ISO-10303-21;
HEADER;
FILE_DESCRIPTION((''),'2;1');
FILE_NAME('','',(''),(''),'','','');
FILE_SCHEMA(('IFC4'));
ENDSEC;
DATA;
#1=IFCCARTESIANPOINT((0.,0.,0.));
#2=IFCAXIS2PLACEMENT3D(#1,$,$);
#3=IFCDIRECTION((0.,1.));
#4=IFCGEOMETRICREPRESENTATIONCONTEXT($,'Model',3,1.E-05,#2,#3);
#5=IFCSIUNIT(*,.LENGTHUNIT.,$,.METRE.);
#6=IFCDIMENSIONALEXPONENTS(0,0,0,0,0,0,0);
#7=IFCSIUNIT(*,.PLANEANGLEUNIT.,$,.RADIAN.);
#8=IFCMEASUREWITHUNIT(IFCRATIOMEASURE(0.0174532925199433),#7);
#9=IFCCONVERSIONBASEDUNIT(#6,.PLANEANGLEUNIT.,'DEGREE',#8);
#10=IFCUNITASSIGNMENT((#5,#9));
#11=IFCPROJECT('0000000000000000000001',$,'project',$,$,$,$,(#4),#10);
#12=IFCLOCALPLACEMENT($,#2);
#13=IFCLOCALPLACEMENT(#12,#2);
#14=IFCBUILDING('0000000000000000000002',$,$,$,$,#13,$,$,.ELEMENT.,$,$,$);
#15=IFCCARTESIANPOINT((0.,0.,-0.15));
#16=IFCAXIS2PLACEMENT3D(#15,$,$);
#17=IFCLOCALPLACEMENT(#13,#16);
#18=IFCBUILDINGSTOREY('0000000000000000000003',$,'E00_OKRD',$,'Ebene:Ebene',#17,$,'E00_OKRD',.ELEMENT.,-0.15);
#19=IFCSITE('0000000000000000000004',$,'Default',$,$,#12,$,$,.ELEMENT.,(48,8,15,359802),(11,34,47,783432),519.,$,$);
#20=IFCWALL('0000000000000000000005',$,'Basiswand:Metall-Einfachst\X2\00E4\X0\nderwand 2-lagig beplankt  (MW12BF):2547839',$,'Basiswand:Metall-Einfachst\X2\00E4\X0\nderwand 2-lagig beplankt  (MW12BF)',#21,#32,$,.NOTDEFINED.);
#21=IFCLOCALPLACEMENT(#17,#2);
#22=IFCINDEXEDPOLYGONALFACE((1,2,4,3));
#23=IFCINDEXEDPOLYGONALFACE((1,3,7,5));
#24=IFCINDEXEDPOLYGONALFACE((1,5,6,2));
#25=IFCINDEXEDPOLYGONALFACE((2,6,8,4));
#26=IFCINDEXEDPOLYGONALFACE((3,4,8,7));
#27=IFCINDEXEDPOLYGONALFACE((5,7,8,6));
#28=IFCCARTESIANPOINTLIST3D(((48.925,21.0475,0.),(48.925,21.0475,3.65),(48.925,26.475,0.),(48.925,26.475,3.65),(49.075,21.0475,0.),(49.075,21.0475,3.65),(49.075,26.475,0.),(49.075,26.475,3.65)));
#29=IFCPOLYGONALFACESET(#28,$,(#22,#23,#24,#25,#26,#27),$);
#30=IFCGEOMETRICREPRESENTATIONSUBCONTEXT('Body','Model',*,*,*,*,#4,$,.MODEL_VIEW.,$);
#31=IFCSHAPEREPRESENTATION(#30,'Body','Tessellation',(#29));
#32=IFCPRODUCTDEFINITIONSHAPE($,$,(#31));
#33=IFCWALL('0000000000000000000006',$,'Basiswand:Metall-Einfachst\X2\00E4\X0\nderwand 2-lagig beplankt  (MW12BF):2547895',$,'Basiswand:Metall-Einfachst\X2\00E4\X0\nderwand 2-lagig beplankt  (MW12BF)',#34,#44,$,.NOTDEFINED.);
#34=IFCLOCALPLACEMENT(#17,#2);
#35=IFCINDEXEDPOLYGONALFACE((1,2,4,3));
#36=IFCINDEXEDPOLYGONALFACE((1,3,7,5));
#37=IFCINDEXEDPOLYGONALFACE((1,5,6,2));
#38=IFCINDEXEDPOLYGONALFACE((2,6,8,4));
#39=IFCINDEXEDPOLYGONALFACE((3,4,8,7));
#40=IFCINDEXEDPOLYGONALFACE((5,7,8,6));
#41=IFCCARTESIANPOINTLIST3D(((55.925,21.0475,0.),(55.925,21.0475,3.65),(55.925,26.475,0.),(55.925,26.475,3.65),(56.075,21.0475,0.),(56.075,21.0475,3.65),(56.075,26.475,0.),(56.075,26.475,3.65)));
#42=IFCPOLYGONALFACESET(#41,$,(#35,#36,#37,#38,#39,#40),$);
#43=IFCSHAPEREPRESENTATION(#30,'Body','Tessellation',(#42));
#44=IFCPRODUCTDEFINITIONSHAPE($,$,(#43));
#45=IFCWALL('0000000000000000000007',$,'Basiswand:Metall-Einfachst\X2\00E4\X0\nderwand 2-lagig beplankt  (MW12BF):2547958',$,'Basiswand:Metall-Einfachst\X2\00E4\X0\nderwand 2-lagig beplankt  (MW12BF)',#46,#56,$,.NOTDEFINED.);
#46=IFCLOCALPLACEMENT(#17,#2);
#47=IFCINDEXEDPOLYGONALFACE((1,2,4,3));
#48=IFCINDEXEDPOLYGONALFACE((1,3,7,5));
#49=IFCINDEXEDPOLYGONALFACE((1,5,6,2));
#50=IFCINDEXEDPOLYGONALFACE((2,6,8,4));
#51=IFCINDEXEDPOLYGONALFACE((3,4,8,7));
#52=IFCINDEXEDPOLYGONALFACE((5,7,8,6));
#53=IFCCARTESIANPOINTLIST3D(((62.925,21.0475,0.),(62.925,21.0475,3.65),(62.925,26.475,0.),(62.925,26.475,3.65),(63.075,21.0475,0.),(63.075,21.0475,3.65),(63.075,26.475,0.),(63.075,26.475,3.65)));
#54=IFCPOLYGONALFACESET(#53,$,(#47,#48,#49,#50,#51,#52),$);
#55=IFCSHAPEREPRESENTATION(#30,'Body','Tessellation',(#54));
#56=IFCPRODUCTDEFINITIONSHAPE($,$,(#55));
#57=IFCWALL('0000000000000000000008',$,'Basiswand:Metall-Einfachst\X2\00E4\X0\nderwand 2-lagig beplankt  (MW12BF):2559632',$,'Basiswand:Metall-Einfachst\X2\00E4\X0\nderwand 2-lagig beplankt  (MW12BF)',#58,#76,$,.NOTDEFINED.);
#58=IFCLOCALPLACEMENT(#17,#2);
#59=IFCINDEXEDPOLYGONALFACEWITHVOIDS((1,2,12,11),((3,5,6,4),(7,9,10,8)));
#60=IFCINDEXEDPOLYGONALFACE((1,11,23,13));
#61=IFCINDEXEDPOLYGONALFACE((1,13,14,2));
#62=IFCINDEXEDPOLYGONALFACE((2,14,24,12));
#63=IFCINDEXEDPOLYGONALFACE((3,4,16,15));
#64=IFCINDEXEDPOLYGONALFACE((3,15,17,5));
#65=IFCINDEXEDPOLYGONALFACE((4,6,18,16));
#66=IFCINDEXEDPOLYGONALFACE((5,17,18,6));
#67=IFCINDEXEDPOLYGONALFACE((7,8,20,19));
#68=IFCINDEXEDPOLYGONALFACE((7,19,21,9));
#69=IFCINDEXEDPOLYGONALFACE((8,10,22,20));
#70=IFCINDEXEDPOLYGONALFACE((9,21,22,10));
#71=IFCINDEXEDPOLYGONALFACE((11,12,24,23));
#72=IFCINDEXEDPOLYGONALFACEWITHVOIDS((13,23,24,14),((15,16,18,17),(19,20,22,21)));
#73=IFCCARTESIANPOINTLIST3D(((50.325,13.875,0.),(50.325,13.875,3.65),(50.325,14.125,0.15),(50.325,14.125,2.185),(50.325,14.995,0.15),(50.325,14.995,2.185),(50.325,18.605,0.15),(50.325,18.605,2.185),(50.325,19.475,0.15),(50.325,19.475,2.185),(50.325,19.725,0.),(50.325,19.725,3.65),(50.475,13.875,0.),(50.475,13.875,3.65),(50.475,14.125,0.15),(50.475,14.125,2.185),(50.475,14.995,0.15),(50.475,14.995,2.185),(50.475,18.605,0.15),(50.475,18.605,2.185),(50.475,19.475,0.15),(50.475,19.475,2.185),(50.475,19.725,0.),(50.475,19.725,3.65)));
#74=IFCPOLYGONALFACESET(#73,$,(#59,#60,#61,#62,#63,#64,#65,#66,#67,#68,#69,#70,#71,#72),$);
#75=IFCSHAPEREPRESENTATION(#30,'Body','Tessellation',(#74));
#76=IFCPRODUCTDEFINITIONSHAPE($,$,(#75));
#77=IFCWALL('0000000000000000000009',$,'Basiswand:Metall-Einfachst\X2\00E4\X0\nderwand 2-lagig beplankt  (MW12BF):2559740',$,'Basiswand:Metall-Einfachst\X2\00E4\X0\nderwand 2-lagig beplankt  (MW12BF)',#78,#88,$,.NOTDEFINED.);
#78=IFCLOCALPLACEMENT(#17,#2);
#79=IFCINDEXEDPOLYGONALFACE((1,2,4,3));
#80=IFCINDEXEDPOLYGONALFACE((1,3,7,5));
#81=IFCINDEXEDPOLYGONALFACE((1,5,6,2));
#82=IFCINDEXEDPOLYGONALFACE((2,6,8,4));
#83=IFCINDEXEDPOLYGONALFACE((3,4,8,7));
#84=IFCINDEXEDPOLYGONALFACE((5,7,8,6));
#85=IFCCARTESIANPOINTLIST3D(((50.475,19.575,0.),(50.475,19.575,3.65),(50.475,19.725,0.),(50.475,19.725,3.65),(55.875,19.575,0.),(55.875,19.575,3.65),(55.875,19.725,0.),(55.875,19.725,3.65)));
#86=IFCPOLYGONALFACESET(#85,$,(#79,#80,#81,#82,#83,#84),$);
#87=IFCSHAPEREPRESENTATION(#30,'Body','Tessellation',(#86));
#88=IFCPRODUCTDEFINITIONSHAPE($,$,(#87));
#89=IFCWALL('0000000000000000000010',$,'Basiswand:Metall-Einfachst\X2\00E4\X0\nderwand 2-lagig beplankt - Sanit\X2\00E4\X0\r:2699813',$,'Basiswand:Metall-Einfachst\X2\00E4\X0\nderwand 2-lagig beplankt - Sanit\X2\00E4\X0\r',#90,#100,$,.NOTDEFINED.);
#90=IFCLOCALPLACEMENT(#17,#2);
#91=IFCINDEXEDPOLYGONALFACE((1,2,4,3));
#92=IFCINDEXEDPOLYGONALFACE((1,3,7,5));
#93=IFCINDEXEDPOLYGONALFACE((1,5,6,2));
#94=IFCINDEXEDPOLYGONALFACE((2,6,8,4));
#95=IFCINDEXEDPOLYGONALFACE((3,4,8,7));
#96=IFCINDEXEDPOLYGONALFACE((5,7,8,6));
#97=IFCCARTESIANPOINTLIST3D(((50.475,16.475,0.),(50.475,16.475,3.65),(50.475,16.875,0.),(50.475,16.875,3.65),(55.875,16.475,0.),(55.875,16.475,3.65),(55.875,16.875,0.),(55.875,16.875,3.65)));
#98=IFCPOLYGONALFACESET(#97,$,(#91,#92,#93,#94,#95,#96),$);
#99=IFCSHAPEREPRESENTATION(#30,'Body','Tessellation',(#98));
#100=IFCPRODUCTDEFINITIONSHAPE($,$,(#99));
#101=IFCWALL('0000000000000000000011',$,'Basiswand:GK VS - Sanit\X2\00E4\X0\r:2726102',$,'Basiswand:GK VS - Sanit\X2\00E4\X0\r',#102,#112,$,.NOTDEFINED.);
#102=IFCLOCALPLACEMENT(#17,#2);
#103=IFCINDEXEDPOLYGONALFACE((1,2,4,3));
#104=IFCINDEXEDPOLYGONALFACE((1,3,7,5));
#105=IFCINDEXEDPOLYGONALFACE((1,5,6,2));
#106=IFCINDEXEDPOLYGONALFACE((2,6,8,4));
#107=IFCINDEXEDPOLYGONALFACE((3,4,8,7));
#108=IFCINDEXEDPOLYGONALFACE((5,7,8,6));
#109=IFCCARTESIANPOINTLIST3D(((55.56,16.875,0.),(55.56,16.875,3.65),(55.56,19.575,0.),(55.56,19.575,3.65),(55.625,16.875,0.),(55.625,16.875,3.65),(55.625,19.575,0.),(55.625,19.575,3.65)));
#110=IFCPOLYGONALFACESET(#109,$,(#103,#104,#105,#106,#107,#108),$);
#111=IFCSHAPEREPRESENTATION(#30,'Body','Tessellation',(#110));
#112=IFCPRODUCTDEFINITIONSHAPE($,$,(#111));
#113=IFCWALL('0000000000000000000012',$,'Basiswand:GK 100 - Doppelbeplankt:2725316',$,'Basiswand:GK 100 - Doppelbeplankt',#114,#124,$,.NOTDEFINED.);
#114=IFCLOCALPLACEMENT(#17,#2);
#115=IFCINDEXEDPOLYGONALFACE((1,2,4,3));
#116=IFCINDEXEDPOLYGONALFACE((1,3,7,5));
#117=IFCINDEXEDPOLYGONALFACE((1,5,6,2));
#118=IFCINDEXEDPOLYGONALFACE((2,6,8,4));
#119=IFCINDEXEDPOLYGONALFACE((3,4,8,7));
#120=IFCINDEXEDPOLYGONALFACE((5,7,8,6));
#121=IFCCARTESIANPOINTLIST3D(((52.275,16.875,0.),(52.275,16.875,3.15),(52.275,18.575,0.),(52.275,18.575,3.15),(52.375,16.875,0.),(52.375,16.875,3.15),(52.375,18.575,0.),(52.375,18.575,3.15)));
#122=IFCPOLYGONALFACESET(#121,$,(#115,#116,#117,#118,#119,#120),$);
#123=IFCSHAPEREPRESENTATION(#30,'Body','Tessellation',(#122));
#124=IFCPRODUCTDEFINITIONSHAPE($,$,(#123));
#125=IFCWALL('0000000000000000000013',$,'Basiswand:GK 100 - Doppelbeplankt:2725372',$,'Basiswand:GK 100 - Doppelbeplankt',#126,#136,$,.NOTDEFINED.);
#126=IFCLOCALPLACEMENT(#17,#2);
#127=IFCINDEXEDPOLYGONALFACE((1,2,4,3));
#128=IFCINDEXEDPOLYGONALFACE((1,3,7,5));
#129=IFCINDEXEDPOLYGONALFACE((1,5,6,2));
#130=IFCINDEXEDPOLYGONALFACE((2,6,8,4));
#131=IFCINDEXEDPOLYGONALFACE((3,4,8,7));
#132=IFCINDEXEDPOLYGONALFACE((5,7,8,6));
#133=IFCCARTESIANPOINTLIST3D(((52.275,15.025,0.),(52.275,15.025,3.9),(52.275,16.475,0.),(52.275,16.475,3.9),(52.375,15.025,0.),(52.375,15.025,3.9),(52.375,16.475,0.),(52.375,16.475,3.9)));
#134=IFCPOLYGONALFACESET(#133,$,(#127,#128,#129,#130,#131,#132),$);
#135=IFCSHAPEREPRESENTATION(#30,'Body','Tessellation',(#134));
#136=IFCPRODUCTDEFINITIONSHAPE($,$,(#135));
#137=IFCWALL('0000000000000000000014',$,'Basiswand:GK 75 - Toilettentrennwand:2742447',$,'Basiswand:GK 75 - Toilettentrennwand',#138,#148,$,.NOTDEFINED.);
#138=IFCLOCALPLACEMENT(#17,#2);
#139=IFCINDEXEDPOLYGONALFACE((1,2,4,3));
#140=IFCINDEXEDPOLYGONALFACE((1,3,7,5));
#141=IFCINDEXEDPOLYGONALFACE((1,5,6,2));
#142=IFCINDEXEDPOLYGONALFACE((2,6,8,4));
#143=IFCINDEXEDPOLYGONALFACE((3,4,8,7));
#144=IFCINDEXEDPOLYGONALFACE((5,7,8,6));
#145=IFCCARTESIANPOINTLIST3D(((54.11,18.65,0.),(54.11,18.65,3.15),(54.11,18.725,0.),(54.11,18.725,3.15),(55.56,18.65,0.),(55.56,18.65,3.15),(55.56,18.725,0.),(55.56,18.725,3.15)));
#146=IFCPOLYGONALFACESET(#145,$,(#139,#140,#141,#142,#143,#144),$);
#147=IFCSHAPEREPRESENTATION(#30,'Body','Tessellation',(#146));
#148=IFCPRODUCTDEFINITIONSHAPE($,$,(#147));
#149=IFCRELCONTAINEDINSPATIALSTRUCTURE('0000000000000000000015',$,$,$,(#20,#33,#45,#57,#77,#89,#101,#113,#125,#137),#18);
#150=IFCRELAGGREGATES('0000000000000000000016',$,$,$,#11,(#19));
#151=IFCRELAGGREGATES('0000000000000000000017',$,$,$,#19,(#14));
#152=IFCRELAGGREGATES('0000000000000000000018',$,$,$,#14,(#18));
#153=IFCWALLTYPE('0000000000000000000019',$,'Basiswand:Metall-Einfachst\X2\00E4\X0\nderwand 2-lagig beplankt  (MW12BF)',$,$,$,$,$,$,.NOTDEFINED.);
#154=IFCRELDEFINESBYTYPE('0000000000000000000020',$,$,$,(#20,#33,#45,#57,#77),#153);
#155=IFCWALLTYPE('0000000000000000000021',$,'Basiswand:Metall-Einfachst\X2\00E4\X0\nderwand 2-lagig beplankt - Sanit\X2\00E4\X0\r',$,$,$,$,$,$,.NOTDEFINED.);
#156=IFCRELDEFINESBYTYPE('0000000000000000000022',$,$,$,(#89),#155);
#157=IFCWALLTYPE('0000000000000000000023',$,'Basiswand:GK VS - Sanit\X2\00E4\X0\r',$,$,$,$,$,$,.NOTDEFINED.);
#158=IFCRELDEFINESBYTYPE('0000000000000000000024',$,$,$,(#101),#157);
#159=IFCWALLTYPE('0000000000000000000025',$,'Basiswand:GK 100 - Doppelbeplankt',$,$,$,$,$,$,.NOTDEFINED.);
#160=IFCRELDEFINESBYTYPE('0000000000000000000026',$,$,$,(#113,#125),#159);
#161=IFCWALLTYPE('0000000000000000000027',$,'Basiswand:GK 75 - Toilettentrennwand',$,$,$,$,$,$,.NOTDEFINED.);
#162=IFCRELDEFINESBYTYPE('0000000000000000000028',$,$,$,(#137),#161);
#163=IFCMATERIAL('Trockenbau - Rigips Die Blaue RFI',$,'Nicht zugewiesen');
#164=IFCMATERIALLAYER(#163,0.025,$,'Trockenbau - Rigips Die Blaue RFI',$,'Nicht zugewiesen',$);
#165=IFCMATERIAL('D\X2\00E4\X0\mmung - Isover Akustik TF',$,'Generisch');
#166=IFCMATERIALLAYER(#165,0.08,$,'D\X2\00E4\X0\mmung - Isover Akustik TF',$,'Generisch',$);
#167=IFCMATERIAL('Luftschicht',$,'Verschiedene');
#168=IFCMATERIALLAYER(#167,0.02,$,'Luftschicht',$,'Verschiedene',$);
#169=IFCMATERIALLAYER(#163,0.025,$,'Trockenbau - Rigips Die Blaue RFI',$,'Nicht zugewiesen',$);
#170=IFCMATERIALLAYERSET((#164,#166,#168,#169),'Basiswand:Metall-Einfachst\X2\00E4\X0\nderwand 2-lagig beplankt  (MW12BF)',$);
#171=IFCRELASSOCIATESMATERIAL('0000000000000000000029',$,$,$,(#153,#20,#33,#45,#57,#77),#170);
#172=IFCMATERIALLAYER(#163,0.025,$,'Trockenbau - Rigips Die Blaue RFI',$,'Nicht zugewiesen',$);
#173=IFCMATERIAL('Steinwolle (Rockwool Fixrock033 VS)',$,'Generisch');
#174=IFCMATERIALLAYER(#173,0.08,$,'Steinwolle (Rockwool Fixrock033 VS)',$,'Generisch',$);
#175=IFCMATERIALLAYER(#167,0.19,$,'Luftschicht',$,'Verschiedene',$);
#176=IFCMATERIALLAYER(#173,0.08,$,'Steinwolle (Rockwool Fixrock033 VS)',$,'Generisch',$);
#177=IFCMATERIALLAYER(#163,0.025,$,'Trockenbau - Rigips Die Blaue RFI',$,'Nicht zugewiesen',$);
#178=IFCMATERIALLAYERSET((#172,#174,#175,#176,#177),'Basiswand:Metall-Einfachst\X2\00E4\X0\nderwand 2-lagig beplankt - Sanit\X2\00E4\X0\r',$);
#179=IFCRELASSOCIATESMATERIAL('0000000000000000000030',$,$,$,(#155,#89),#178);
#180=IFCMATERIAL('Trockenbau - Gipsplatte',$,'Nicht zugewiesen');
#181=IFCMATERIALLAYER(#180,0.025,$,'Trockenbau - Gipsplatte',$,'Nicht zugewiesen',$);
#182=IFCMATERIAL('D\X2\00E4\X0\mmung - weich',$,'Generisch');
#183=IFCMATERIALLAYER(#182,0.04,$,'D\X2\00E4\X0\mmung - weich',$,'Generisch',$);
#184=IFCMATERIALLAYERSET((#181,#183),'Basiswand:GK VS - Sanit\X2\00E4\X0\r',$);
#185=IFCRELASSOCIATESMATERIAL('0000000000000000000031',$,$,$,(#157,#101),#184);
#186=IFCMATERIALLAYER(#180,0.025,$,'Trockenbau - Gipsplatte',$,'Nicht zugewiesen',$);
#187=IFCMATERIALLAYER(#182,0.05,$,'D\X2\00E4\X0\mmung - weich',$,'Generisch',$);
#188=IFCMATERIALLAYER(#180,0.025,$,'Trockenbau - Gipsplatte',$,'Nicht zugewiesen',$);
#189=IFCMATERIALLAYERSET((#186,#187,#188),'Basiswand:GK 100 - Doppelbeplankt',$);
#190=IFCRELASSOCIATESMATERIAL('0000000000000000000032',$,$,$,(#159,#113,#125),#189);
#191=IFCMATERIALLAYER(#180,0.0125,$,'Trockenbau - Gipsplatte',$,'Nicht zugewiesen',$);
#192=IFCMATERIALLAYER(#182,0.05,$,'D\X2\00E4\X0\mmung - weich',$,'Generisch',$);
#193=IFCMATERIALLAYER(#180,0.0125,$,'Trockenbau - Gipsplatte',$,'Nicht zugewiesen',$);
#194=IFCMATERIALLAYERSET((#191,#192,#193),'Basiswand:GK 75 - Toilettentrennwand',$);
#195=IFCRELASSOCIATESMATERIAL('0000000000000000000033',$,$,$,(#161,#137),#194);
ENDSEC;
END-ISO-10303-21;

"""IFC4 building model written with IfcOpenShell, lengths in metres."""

from ifc_helpers import new_model, entity, si_unit, converted_unit, direction, frame, frame_2d, origin, place, context, subcontext, project, spatial, rectangle, extrude, material, layer, layer_set, layer_usage, type_object, element, save


model = new_model("IFC4")

# Units and contexts
model_context = context("Model", 3, precision=1e-05, world=origin(), true_north=direction((0.0, 1.0)))
body_context = subcontext(model_context, "Body", "Model", "MODEL_VIEW")
ifc_project = project(units=[si_unit("LENGTHUNIT", "METRE"), converted_unit("PLANEANGLEUNIT", "DEGREE", entity("IfcRatioMeasure", 0.0174532925199433), si_unit("PLANEANGLEUNIT", "RADIAN"), dimensions=[0, 0, 0, 0, 0, 0, 0])], contexts=[model_context])

# Site, building, storey
site_placement = place(None, frame((0.0, 0.0, 0.0)))
site = spatial("IfcSite", under=ifc_project, at=site_placement, Name="Default", CompositionType="ELEMENT", RefLatitude=(48, 8, 15, 359802), RefLongitude=(11, 34, 47, 783432), RefElevation=519.0)
building_placement = place(site_placement, origin())
building = spatial("IfcBuilding", under=site, at=building_placement, CompositionType="ELEMENT")
storey_placement = place(building_placement, frame((0.0, 0.0, -0.15)))
storey = spatial("IfcBuildingStorey", under=building, at=storey_placement, Name="E00_OKRD", ObjectType="Ebene:Ebene", LongName="E00_OKRD", CompositionType="ELEMENT", Elevation=-0.15)

# Walls
ifc_material_1 = material(Name="Trockenbau - Rigips Die Blaue RFI", Category="Nicht zugewiesen")
ifc_layer_1 = layer(ifc_material_1, 0.025, Name="Trockenbau - Rigips Die Blaue RFI", Category="Nicht zugewiesen")
ifc_material_2 = material(Name="Dämmung - Isover Akustik TF", Category="Generisch")
ifc_layer_2 = layer(ifc_material_2, 0.08, Name="Dämmung - Isover Akustik TF", Category="Generisch")
ifc_material_3 = material(Name="Luftschicht", Category="Verschiedene")
ifc_layer_3 = layer(ifc_material_3, 0.02, Name="Luftschicht", Category="Verschiedene")
ifc_layer_4 = layer(ifc_material_1, 0.025, Name="Trockenbau - Rigips Die Blaue RFI", Category="Nicht zugewiesen")
ifc_layer_set_1 = layer_set([ifc_layer_1, ifc_layer_2, ifc_layer_3, ifc_layer_4], Name="Basiswand:Metall-Einfachständerwand 2-lagig beplankt  (MW12BF)")
ifc_layer_usage_1 = layer_usage(ifc_layer_set_1, "AXIS2", "NEGATIVE", 0.075)
wall_type_1 = type_object("IfcWallType", Name="Basiswand:Metall-Einfachständerwand 2-lagig beplankt  (MW12BF)", PredefinedType="NOTDEFINED", material=ifc_layer_set_1)
wall_1_placement = place(storey_placement, frame((49.0, 26.475, 0.0), z_axis=(0.0, 0.0, 1.0), x_axis=(0.0, -1.0, 0.0)))
element("IfcWall", 1, at=wall_1_placement, inside=storey, type_object=wall_type_1, material=ifc_layer_usage_1, Name="Basiswand:Metall-Einfachständerwand 2-lagig beplankt  (MW12BF):2547839", ObjectType="Basiswand:Metall-Einfachständerwand 2-lagig beplankt  (MW12BF)", PredefinedType="NOTDEFINED", context=body_context, shape_type="SweptSolid", body=[
    extrude(rectangle(XDim=5.4275, YDim=0.15, at=frame_2d((2.7137, 0.0), x_axis=(-1.0, 0.0))), origin(), (0.0, 0.0, 1.0), 3.65),
])
ifc_layer_usage_2 = layer_usage(ifc_layer_set_1, "AXIS2", "NEGATIVE", 0.075)
wall_2_placement = place(storey_placement, frame((56.0, 26.475, 0.0), z_axis=(0.0, 0.0, 1.0), x_axis=(0.0, -1.0, 0.0)))
element("IfcWall", 2, at=wall_2_placement, inside=storey, type_object=wall_type_1, material=ifc_layer_usage_2, Name="Basiswand:Metall-Einfachständerwand 2-lagig beplankt  (MW12BF):2547895", ObjectType="Basiswand:Metall-Einfachständerwand 2-lagig beplankt  (MW12BF)", PredefinedType="NOTDEFINED", context=body_context, shape_type="SweptSolid", body=[
    extrude(rectangle(XDim=5.4275, YDim=0.15, at=frame_2d((2.7137, 0.0), x_axis=(-1.0, 0.0))), origin(), (0.0, 0.0, 1.0), 3.65),
])
ifc_layer_usage_3 = layer_usage(ifc_layer_set_1, "AXIS2", "NEGATIVE", 0.075)
wall_3_placement = place(storey_placement, frame((63.0, 26.475, 0.0), z_axis=(0.0, 0.0, 1.0), x_axis=(0.0, -1.0, 0.0)))
element("IfcWall", 3, at=wall_3_placement, inside=storey, type_object=wall_type_1, material=ifc_layer_usage_3, Name="Basiswand:Metall-Einfachständerwand 2-lagig beplankt  (MW12BF):2547958", ObjectType="Basiswand:Metall-Einfachständerwand 2-lagig beplankt  (MW12BF)", PredefinedType="NOTDEFINED", context=body_context, shape_type="SweptSolid", body=[
    extrude(rectangle(XDim=5.4275, YDim=0.15, at=frame_2d((2.7137, 0.0), x_axis=(-1.0, 0.0))), origin(), (0.0, 0.0, 1.0), 3.65),
])

# Wall, openings
ifc_layer_usage_4 = layer_usage(ifc_layer_set_1, "AXIS2", "NEGATIVE", 0.075)
wall_4_placement = place(storey_placement, frame((50.4, 19.725, 0.0), z_axis=(0.0, 0.0, 1.0), x_axis=(0.0, -1.0, 0.0)))
wall_4 = element("IfcWall", 4, at=wall_4_placement, inside=storey, type_object=wall_type_1, material=ifc_layer_usage_4, Name="Basiswand:Metall-Einfachständerwand 2-lagig beplankt  (MW12BF):2559632", ObjectType="Basiswand:Metall-Einfachständerwand 2-lagig beplankt  (MW12BF)", PredefinedType="NOTDEFINED", context=body_context, shape_type="SweptSolid", body=[
    extrude(rectangle(XDim=5.85, YDim=0.15, at=frame_2d((2.925, 0.0), x_axis=(-1.0, 0.0))), origin(), (0.0, 0.0, 1.0), 3.65),
])
opening_1_placement = place(wall_4_placement, frame((4.73, -0.075, 0.15)))
element("IfcOpeningElement", 5, at=opening_1_placement, cuts=wall_4, ObjectType="Opening", PredefinedType="OPENING", context=body_context, shape_type="SweptSolid", body=[
    extrude(rectangle(XDim=2.035, YDim=0.87, at=frame_2d((1.0175, 0.435), x_axis=(-1.0, 0.0))), frame((0.0, 0.0, 0.0), z_axis=(0.0, 1.0, 0.0), x_axis=(0.0, 0.0, 1.0)), (0.0, 0.0, 1.0), 0.15),
])
opening_2_placement = place(wall_4_placement, frame((0.25, -0.075, 0.15)))
element("IfcOpeningElement", 6, at=opening_2_placement, cuts=wall_4, ObjectType="Opening", PredefinedType="OPENING", context=body_context, shape_type="SweptSolid", body=[
    extrude(rectangle(XDim=2.035, YDim=0.87, at=frame_2d((1.0175, 0.435), x_axis=(-1.0, 0.0))), frame((0.0, 0.0, 0.0), z_axis=(0.0, 1.0, 0.0), x_axis=(0.0, 0.0, 1.0)), (0.0, 0.0, 1.0), 0.15),
])

# Walls
ifc_layer_usage_5 = layer_usage(ifc_layer_set_1, "AXIS2", "POSITIVE", -0.075)
wall_5_placement = place(storey_placement, frame((55.875, 19.65, 0.0), z_axis=(0.0, 0.0, 1.0), x_axis=(-1.0, 0.0, 0.0)))
element("IfcWall", 7, at=wall_5_placement, inside=storey, type_object=wall_type_1, material=ifc_layer_usage_5, Name="Basiswand:Metall-Einfachständerwand 2-lagig beplankt  (MW12BF):2559740", ObjectType="Basiswand:Metall-Einfachständerwand 2-lagig beplankt  (MW12BF)", PredefinedType="NOTDEFINED", context=body_context, shape_type="SweptSolid", body=[
    extrude(rectangle(XDim=5.4, YDim=0.15, at=frame_2d((2.7, 0.0), x_axis=(-1.0, 0.0))), origin(), (0.0, 0.0, 1.0), 3.65),
])
ifc_layer_5 = layer(ifc_material_1, 0.025, Name="Trockenbau - Rigips Die Blaue RFI", Category="Nicht zugewiesen")
ifc_material_4 = material(Name="Steinwolle (Rockwool Fixrock033 VS)", Category="Generisch")
ifc_layer_6 = layer(ifc_material_4, 0.08, Name="Steinwolle (Rockwool Fixrock033 VS)", Category="Generisch")
ifc_layer_7 = layer(ifc_material_3, 0.19, Name="Luftschicht", Category="Verschiedene")
ifc_layer_8 = layer(ifc_material_4, 0.08, Name="Steinwolle (Rockwool Fixrock033 VS)", Category="Generisch")
ifc_layer_9 = layer(ifc_material_1, 0.025, Name="Trockenbau - Rigips Die Blaue RFI", Category="Nicht zugewiesen")
ifc_layer_set_2 = layer_set([ifc_layer_5, ifc_layer_6, ifc_layer_7, ifc_layer_8, ifc_layer_9], Name="Basiswand:Metall-Einfachständerwand 2-lagig beplankt - Sanitär")
ifc_layer_usage_6 = layer_usage(ifc_layer_set_2, "AXIS2", "NEGATIVE", 0.2)
wall_type_2 = type_object("IfcWallType", Name="Basiswand:Metall-Einfachständerwand 2-lagig beplankt - Sanitär", PredefinedType="NOTDEFINED", material=ifc_layer_set_2)
wall_6_placement = place(storey_placement, frame((55.875, 16.675, 0.0), z_axis=(0.0, 0.0, 1.0), x_axis=(-1.0, 0.0, 0.0)))
element("IfcWall", 8, at=wall_6_placement, inside=storey, type_object=wall_type_2, material=ifc_layer_usage_6, Name="Basiswand:Metall-Einfachständerwand 2-lagig beplankt - Sanitär:2699813", ObjectType="Basiswand:Metall-Einfachständerwand 2-lagig beplankt - Sanitär", PredefinedType="NOTDEFINED", context=body_context, shape_type="SweptSolid", body=[
    extrude(rectangle(XDim=5.4, YDim=0.4, at=frame_2d((2.7, 0.0), x_axis=(-1.0, 0.0))), origin(), (0.0, 0.0, 1.0), 3.65),
])
ifc_material_5 = material(Name="Trockenbau - Gipsplatte", Category="Nicht zugewiesen")
ifc_layer_10 = layer(ifc_material_5, 0.025, Name="Trockenbau - Gipsplatte", Category="Nicht zugewiesen")
ifc_material_6 = material(Name="Dämmung - weich", Category="Generisch")
ifc_layer_11 = layer(ifc_material_6, 0.04, Name="Dämmung - weich", Category="Generisch")
ifc_layer_set_3 = layer_set([ifc_layer_10, ifc_layer_11], Name="Basiswand:GK VS - Sanitär")
ifc_layer_usage_7 = layer_usage(ifc_layer_set_3, "AXIS2", "POSITIVE", -0.0325)
wall_type_3 = type_object("IfcWallType", Name="Basiswand:GK VS - Sanitär", PredefinedType="NOTDEFINED", material=ifc_layer_set_3)
wall_7_placement = place(storey_placement, frame((55.5925, 19.575, 0.0), z_axis=(0.0, 0.0, 1.0), x_axis=(0.0, -1.0, 0.0)))
element("IfcWall", 9, at=wall_7_placement, inside=storey, type_object=wall_type_3, material=ifc_layer_usage_7, Name="Basiswand:GK VS - Sanitär:2726102", ObjectType="Basiswand:GK VS - Sanitär", PredefinedType="NOTDEFINED", context=body_context, shape_type="SweptSolid", body=[
    extrude(rectangle(XDim=2.7, YDim=0.065, at=frame_2d((1.35, 0.0), x_axis=(-1.0, 0.0))), origin(), (0.0, 0.0, 1.0), 3.65),
])
ifc_layer_12 = layer(ifc_material_5, 0.025, Name="Trockenbau - Gipsplatte", Category="Nicht zugewiesen")
ifc_layer_13 = layer(ifc_material_6, 0.05, Name="Dämmung - weich", Category="Generisch")
ifc_layer_14 = layer(ifc_material_5, 0.025, Name="Trockenbau - Gipsplatte", Category="Nicht zugewiesen")
ifc_layer_set_4 = layer_set([ifc_layer_12, ifc_layer_13, ifc_layer_14], Name="Basiswand:GK 100 - Doppelbeplankt")
ifc_layer_usage_8 = layer_usage(ifc_layer_set_4, "AXIS2", "NEGATIVE", 0.05)
wall_type_4 = type_object("IfcWallType", Name="Basiswand:GK 100 - Doppelbeplankt", PredefinedType="NOTDEFINED", material=ifc_layer_set_4)
wall_8_placement = place(storey_placement, frame((52.325, 16.875, 0.0), z_axis=(0.0, 0.0, 1.0), x_axis=(0.0, 1.0, 0.0)))
element("IfcWall", 10, at=wall_8_placement, inside=storey, type_object=wall_type_4, material=ifc_layer_usage_8, Name="Basiswand:GK 100 - Doppelbeplankt:2725316", ObjectType="Basiswand:GK 100 - Doppelbeplankt", PredefinedType="NOTDEFINED", context=body_context, shape_type="SweptSolid", body=[
    extrude(rectangle(XDim=1.7, YDim=0.1, at=frame_2d((0.85, 0.0), x_axis=(-1.0, 0.0))), origin(), (0.0, 0.0, 1.0), 3.15),
])
ifc_layer_usage_9 = layer_usage(ifc_layer_set_4, "AXIS2", "NEGATIVE", 0.05)
wall_9_placement = place(storey_placement, frame((52.325, 16.475, 0.0), z_axis=(0.0, 0.0, 1.0), x_axis=(0.0, -1.0, 0.0)))
element("IfcWall", 11, at=wall_9_placement, inside=storey, type_object=wall_type_4, material=ifc_layer_usage_9, Name="Basiswand:GK 100 - Doppelbeplankt:2725372", ObjectType="Basiswand:GK 100 - Doppelbeplankt", PredefinedType="NOTDEFINED", context=body_context, shape_type="SweptSolid", body=[
    extrude(rectangle(XDim=1.45, YDim=0.1, at=frame_2d((0.725, 0.0), x_axis=(-1.0, 0.0))), origin(), (0.0, 0.0, 1.0), 3.9),
])
ifc_layer_15 = layer(ifc_material_5, 0.0125, Name="Trockenbau - Gipsplatte", Category="Nicht zugewiesen")
ifc_layer_16 = layer(ifc_material_6, 0.05, Name="Dämmung - weich", Category="Generisch")
ifc_layer_17 = layer(ifc_material_5, 0.0125, Name="Trockenbau - Gipsplatte", Category="Nicht zugewiesen")
ifc_layer_set_5 = layer_set([ifc_layer_15, ifc_layer_16, ifc_layer_17], Name="Basiswand:GK 75 - Toilettentrennwand")
ifc_layer_usage_10 = layer_usage(ifc_layer_set_5, "AXIS2", "POSITIVE", -0.0375)
wall_type_5 = type_object("IfcWallType", Name="Basiswand:GK 75 - Toilettentrennwand", PredefinedType="NOTDEFINED", material=ifc_layer_set_5)
wall_10_placement = place(storey_placement, frame((55.56, 18.6875, 0.0), z_axis=(0.0, 0.0, 1.0), x_axis=(-1.0, 0.0, 0.0)))
element("IfcWall", 12, at=wall_10_placement, inside=storey, type_object=wall_type_5, material=ifc_layer_usage_10, Name="Basiswand:GK 75 - Toilettentrennwand:2742447", ObjectType="Basiswand:GK 75 - Toilettentrennwand", PredefinedType="NOTDEFINED", context=body_context, shape_type="SweptSolid", body=[
    extrude(rectangle(XDim=1.45, YDim=0.075, at=frame_2d((0.725, 0.0), x_axis=(-1.0, 0.0))), origin(), (0.0, 0.0, 1.0), 3.15),
])

save(model, "model.ifc")
